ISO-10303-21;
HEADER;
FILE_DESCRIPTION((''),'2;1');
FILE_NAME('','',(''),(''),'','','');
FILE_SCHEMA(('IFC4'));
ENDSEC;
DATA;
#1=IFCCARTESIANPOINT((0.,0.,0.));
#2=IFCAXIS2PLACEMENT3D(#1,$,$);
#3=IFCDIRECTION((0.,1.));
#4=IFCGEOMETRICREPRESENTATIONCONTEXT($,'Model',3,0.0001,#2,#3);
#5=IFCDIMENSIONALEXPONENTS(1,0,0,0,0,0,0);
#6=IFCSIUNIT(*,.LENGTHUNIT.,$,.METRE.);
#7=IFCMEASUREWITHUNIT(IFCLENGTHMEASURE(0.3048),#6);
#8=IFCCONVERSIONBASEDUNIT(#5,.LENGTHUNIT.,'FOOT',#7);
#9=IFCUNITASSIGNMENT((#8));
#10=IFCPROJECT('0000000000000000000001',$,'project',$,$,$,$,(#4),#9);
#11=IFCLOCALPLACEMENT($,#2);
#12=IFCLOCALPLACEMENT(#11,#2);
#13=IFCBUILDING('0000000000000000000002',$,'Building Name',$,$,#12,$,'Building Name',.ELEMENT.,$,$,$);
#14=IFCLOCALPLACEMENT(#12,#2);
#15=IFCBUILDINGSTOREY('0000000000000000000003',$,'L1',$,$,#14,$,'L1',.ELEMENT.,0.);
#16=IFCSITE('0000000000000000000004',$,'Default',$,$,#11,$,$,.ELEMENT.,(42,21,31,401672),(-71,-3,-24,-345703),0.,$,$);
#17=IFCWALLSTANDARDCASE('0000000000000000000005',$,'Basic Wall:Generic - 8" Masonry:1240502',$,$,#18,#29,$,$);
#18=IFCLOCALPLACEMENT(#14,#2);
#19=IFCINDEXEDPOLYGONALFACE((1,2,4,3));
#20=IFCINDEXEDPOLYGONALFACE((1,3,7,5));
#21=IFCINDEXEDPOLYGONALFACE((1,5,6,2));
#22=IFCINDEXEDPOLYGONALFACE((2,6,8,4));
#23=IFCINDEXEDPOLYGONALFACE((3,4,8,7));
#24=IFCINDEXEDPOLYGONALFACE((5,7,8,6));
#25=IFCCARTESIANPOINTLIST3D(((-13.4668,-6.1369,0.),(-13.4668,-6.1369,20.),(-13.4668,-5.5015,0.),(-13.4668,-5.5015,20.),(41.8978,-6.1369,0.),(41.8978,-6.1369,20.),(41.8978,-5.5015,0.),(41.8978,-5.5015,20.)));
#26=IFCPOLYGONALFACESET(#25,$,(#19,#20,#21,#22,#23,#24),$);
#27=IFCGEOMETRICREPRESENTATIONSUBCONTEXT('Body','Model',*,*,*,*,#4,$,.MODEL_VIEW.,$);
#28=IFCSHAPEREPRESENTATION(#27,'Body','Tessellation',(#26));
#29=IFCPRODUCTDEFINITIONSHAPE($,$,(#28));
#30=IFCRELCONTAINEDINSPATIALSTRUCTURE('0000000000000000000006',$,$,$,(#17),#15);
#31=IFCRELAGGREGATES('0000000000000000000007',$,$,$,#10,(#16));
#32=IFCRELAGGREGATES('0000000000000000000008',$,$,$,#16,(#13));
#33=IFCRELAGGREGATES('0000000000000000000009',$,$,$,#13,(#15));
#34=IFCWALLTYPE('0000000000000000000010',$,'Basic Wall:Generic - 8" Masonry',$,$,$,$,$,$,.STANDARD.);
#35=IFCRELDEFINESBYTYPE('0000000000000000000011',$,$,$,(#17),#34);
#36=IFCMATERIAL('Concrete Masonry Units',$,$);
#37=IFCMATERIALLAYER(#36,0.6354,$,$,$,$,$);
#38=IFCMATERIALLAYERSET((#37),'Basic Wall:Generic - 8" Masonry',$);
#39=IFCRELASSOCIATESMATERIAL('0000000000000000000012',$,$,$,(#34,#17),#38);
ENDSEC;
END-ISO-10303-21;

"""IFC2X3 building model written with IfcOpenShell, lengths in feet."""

from ifc_helpers import new_model, entity, si_unit, converted_unit, direction, frame, frame_2d, origin, place, context, subcontext, project, spatial, rectangle, extrude, material, layer, layer_set, layer_usage, type_object, element, save


model = new_model("IFC2X3")

# Units and contexts
model_context = context("Model", 3, precision=0.0001, world=origin(), true_north=direction((0.0, 1.0)))
body_context = subcontext(model_context, "Body", "Model", "MODEL_VIEW")
ifc_project = project(units=[converted_unit("LENGTHUNIT", "FOOT", entity("IfcLengthMeasure", 0.3048), si_unit("LENGTHUNIT", "METRE"), dimensions=[1, 0, 0, 0, 0, 0, 0])], contexts=[model_context])

# Site, building, storey
site_placement = place(None, origin())
site = spatial("IfcSite", under=ifc_project, at=site_placement, Name="Default", CompositionType="ELEMENT", RefLatitude=(42, 21, 31, 401672), RefLongitude=(-71, -3, -24, -345703), RefElevation=0.0)
building_placement = place(site_placement, origin())
building = spatial("IfcBuilding", under=site, at=building_placement, Name="Building Name", LongName="Building Name", CompositionType="ELEMENT")
storey_placement = place(building_placement, origin())
storey = spatial("IfcBuildingStorey", under=building, at=storey_placement, Name="L1", LongName="L1", CompositionType="ELEMENT", Elevation=0.0)

# Shared definitions
ifc_material = material(Name="Concrete Masonry Units")
ifc_layer = layer(ifc_material, 0.6354)
ifc_layer_set = layer_set([ifc_layer], Name="Basic Wall:Generic - 8\" Masonry")
wall_type = type_object("IfcWallType", Name="Basic Wall:Generic - 8\" Masonry", PredefinedType="STANDARD", material=ifc_layer_set)

# Wall
ifc_layer_usage_1 = layer_usage(ifc_layer_set, "AXIS2", "NEGATIVE", 0.3177)
wall_1_placement = place(storey_placement, frame((41.8978, -5.8192, 0.0), z_axis=(0.0, 0.0, 1.0), x_axis=(-1.0, 0.0, 0.0)))
element("IfcWallStandardCase", 1, at=wall_1_placement, inside=storey, type_object=wall_type, material=ifc_layer_usage_1, Name="Basic Wall:Generic - 8\" Masonry:1240502", context=body_context, shape_type="SweptSolid", body=[
    extrude(rectangle(XDim=55.3646, YDim=0.6354, at=frame_2d((27.6823, 0.0), x_axis=(-1.0, 0.0))), origin(), (0.0, 0.0, 1.0), 20.0),
])

save(model, "model.ifc")
